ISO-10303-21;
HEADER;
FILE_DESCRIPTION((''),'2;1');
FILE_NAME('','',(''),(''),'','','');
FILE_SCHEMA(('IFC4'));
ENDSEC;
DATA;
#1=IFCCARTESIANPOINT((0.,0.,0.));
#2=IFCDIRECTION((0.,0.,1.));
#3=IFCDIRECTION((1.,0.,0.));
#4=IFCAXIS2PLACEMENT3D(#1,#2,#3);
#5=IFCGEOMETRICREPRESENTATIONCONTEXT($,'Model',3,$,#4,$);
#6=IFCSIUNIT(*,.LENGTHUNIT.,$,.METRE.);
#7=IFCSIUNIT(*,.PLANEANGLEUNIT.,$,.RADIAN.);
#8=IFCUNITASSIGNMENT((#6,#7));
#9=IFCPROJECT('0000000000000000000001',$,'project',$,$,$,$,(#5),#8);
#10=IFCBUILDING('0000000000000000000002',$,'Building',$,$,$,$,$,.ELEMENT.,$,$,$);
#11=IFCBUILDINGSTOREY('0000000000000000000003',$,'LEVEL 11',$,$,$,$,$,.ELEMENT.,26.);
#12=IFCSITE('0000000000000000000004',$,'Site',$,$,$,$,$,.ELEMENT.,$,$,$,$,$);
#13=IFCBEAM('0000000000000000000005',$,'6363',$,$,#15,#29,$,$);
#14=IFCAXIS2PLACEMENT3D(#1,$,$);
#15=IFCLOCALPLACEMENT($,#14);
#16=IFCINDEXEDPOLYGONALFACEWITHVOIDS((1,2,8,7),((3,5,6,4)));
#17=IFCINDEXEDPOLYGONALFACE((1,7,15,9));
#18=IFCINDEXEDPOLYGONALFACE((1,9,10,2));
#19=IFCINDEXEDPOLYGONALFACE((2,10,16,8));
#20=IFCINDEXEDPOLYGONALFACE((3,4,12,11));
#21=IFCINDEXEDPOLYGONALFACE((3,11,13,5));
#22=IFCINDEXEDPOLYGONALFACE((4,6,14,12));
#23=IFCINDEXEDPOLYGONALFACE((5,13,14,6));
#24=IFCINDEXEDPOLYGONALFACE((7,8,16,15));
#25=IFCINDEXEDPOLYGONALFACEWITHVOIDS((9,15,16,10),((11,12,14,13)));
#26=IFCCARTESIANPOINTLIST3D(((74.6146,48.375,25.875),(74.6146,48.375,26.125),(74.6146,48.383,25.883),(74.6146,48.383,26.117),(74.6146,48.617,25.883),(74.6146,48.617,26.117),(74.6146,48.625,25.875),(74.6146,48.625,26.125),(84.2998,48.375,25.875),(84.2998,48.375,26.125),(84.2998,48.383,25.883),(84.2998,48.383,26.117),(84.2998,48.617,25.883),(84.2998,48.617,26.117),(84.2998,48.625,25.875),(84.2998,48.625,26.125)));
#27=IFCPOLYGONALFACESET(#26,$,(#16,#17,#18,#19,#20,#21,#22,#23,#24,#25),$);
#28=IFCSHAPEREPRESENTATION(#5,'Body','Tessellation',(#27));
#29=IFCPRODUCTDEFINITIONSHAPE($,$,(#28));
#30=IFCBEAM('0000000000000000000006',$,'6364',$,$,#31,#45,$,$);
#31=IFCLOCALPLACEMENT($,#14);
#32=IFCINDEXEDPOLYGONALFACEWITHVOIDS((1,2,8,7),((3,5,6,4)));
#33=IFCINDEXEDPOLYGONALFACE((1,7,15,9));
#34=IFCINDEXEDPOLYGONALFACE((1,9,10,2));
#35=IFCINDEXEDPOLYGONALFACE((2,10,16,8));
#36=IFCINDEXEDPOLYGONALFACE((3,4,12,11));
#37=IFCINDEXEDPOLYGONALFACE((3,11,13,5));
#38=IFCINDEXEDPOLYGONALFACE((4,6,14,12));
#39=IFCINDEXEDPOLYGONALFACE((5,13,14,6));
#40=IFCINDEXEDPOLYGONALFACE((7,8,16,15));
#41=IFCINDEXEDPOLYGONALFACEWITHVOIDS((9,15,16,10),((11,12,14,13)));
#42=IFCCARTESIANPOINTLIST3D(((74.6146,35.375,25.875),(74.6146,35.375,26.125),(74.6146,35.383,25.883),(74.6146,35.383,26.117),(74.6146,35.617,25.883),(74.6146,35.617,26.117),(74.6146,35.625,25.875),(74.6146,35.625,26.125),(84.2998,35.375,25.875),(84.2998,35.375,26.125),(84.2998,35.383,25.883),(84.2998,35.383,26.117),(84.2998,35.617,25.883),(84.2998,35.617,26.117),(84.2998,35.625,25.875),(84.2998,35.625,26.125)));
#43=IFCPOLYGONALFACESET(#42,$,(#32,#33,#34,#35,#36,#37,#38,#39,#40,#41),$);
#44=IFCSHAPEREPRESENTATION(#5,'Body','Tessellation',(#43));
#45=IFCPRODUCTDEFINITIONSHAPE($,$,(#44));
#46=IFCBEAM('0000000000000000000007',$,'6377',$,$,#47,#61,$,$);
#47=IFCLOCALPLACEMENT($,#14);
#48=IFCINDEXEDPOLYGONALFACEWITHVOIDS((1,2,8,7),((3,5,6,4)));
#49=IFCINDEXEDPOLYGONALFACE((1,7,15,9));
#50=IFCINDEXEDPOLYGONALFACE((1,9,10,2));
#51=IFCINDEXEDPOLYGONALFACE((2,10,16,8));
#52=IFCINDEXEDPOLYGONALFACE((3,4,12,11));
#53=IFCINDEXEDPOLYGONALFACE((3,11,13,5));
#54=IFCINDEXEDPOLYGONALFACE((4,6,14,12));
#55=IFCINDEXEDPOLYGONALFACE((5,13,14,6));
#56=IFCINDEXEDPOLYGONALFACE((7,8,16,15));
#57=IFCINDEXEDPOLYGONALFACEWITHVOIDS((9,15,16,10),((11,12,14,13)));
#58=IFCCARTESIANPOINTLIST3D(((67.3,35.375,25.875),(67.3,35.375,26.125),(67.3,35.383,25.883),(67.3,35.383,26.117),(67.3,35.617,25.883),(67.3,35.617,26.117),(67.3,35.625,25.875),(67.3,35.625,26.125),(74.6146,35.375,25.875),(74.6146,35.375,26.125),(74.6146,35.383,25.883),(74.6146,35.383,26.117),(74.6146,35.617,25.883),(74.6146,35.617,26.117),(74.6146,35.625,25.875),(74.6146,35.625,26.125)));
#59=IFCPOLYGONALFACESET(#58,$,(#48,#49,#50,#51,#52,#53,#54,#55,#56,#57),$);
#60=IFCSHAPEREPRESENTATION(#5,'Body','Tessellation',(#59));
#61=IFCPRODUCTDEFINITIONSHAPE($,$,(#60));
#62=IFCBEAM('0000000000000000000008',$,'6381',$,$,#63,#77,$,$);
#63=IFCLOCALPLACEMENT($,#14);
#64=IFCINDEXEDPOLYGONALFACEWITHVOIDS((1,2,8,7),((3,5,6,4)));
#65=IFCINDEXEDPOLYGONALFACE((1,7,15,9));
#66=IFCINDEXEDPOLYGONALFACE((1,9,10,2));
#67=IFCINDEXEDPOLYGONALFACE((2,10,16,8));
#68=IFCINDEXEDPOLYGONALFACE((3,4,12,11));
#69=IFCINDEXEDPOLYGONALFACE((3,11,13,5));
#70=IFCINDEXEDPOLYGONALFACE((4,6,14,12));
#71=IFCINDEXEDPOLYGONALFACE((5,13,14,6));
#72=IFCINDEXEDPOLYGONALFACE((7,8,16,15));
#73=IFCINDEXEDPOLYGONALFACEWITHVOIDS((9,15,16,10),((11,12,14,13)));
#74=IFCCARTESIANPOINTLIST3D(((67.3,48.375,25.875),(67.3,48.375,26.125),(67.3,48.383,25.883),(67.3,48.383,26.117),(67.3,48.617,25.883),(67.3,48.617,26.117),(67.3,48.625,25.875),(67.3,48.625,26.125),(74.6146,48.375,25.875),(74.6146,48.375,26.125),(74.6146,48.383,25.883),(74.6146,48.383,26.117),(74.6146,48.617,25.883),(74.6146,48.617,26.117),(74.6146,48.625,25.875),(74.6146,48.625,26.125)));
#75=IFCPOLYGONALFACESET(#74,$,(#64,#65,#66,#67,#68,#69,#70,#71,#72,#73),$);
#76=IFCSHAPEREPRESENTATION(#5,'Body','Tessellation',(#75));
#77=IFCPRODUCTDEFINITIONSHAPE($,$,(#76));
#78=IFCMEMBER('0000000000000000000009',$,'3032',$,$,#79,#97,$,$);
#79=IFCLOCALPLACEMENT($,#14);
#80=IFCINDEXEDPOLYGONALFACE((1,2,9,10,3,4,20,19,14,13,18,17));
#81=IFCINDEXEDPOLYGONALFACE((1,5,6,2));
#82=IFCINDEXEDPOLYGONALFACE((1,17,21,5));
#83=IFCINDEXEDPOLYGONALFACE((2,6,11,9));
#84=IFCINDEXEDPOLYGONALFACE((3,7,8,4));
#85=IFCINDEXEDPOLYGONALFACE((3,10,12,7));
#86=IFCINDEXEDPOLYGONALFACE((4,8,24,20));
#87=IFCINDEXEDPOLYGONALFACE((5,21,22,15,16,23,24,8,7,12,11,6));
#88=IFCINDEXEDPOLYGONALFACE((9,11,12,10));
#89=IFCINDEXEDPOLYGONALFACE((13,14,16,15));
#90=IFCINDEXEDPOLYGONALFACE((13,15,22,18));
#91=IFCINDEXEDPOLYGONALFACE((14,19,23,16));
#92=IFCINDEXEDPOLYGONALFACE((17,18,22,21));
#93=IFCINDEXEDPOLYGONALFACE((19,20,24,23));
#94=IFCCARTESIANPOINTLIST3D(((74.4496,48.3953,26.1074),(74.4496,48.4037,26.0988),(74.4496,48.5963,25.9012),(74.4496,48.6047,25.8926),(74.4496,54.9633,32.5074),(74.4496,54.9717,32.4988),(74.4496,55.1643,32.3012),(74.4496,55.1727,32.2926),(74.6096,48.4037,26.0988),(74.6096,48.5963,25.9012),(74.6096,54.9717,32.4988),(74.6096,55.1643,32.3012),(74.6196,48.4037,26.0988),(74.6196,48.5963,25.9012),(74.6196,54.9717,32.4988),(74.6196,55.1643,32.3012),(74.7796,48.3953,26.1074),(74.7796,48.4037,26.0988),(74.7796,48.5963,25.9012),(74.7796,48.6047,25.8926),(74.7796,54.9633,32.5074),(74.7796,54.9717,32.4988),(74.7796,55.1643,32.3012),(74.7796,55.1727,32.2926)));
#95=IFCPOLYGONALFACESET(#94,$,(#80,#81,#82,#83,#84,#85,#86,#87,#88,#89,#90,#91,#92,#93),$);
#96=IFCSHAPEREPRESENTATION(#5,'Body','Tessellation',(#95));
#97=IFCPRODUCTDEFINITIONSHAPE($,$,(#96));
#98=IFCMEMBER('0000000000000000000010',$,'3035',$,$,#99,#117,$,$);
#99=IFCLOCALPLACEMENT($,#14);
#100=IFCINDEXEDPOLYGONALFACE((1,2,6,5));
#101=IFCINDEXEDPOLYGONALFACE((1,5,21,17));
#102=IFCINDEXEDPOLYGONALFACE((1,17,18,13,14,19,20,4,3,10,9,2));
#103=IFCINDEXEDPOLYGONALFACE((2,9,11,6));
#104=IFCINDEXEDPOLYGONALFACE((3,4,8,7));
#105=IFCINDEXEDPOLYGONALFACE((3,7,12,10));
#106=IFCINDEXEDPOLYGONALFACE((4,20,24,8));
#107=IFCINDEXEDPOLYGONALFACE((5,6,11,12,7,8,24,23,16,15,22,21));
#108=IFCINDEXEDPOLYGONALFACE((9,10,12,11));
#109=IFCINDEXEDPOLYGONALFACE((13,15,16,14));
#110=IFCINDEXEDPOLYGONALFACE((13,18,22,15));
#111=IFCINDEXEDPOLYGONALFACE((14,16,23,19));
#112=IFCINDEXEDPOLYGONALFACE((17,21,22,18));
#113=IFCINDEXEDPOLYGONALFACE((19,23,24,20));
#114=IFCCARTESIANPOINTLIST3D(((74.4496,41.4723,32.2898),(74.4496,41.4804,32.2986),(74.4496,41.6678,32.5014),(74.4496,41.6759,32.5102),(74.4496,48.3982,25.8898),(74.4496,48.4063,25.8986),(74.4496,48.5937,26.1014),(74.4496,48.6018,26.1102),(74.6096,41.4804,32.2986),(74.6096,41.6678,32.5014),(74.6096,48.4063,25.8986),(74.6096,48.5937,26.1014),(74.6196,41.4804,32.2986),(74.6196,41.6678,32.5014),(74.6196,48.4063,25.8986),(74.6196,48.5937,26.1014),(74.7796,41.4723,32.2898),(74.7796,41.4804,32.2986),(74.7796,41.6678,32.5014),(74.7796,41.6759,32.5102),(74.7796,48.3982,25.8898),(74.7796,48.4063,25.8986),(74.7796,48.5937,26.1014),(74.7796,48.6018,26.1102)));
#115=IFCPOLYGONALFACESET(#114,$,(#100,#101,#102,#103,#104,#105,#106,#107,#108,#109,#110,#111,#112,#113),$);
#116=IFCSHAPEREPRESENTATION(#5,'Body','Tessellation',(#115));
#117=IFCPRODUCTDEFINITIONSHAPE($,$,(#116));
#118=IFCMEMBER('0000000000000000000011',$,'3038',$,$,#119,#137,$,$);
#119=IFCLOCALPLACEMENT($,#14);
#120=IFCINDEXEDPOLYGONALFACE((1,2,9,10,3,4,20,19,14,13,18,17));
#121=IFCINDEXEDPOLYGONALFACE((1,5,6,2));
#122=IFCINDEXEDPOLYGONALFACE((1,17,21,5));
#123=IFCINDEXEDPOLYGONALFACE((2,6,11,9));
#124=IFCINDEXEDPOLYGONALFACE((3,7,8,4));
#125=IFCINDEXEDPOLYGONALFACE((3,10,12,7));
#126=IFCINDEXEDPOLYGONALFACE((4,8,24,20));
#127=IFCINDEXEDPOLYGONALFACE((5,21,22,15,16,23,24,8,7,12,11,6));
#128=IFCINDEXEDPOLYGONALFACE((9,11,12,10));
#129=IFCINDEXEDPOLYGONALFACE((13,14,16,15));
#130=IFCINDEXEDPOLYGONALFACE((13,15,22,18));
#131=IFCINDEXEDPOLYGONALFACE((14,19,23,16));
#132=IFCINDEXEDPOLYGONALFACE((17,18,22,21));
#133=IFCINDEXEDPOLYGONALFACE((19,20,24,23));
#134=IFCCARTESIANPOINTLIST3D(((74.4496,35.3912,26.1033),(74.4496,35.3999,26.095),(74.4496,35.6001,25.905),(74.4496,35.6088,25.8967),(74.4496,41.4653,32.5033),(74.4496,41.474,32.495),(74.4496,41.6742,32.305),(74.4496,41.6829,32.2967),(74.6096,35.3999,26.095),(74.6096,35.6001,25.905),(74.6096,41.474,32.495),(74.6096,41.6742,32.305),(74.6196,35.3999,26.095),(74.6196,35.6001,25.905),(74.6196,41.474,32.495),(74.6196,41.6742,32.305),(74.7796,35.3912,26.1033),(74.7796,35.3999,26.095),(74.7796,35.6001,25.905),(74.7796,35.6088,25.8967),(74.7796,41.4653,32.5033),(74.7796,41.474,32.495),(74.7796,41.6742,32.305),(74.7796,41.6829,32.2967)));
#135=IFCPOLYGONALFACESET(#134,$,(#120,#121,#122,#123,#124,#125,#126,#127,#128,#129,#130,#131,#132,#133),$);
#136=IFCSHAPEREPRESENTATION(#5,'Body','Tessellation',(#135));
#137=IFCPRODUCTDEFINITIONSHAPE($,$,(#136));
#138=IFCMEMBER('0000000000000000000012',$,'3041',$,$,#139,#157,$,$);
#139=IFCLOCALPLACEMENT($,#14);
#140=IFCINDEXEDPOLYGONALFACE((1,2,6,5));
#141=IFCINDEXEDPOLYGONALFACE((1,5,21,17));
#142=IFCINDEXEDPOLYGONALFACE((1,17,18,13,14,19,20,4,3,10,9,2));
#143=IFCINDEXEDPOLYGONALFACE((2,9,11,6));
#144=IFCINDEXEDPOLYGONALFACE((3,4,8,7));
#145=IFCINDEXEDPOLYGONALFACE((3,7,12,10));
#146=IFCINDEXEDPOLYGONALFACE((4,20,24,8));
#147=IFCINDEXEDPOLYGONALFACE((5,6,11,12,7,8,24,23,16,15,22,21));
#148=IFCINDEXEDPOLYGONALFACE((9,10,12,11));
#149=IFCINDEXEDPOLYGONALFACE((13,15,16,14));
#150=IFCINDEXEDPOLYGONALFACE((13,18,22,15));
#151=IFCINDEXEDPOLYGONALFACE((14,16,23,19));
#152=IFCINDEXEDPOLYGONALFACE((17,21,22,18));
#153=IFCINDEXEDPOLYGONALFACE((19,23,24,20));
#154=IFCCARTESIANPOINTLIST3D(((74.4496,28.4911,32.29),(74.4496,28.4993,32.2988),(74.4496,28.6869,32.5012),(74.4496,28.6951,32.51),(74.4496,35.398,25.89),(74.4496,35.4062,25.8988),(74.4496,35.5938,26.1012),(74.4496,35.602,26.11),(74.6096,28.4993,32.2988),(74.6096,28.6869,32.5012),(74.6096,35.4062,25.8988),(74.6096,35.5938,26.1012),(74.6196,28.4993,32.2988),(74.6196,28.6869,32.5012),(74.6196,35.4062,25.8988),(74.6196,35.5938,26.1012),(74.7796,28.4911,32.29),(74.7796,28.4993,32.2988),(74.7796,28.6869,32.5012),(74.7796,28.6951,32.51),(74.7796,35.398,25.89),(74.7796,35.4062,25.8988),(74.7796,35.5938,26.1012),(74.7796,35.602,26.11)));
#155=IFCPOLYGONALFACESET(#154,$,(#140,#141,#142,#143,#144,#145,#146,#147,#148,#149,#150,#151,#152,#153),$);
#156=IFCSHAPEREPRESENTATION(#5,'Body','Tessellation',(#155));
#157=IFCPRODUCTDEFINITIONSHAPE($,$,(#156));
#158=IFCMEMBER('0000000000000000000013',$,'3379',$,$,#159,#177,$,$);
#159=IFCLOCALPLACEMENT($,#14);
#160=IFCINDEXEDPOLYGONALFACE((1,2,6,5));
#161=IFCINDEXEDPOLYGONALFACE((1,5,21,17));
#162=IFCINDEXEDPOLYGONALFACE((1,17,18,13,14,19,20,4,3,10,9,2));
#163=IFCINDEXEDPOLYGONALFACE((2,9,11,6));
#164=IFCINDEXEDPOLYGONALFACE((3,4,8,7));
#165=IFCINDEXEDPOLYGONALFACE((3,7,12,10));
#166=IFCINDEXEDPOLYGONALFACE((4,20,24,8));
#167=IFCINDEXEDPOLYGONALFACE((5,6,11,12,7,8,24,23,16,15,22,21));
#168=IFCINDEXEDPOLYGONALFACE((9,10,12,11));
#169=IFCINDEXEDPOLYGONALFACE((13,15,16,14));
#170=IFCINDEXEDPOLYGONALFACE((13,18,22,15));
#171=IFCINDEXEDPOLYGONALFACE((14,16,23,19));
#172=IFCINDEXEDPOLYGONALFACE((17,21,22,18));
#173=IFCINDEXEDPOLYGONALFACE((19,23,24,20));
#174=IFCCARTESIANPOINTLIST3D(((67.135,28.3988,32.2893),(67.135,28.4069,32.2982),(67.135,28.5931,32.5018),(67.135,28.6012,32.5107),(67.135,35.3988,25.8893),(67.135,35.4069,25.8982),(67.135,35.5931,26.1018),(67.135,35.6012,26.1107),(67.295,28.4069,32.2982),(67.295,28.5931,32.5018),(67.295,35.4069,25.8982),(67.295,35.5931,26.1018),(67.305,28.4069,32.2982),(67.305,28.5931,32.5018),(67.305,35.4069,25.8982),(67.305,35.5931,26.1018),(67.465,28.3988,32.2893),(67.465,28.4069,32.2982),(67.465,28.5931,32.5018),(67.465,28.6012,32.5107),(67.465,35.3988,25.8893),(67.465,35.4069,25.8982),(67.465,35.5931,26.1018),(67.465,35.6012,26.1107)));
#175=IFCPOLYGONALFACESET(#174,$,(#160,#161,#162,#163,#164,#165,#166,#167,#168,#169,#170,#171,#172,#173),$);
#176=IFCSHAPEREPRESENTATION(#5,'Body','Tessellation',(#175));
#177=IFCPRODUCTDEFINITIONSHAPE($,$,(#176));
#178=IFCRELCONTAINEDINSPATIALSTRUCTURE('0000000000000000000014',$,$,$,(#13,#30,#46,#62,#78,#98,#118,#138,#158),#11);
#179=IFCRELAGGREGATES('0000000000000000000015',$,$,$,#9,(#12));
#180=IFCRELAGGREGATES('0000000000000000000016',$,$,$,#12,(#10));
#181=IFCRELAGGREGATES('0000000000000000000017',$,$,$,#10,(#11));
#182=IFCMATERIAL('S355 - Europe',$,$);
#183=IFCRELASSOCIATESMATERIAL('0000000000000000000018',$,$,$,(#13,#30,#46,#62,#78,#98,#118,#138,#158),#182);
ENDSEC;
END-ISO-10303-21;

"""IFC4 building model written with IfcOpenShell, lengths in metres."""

from ifc_helpers import new_model, si_unit, frame, origin_with_axes, origin_2d_with_axis, place, context, project, spatial, hollow_rectangle, i_section, extrude, material, material_profile, profile_set, profile_usage, element, save


model = new_model("IFC4")

# Units and contexts
model_context = context("Model", 3, world=origin_with_axes())
ifc_project = project(units=[si_unit("LENGTHUNIT", "METRE"), si_unit("PLANEANGLEUNIT", "RADIAN")], contexts=[model_context])

# Site, building, storey
site = spatial("IfcSite", under=ifc_project, Name="Site", CompositionType="ELEMENT")
building = spatial("IfcBuilding", under=site, Name="Building", CompositionType="ELEMENT")
storey = spatial("IfcBuildingStorey", under=building, Name="LEVEL 11", CompositionType="ELEMENT", Elevation=26.0)

# Shared definitions
ifc_material = material(Name="S355 - Europe")

# Beams
ifc_material_profile_1 = material_profile(ifc_material, hollow_rectangle(XDim=0.25, YDim=0.25, WallThickness=0.008, at=origin_2d_with_axis()))
ifc_profile_set_1 = profile_set([ifc_material_profile_1])
ifc_profile_usage_1 = profile_usage(ifc_profile_set_1, cardinal=10)
beam_1_placement = place(None, frame((74.6146, 48.5, 26.0), z_axis=(1.0, 0.0, 0.0), x_axis=(0.0, 1.0, 0.0)))
element("IfcBeam", 1, at=beam_1_placement, inside=storey, material=ifc_profile_usage_1, Name="6363", context=model_context, shape_type="SweptSolid", body=[
    extrude(hollow_rectangle(XDim=0.25, YDim=0.25, WallThickness=0.008, at=origin_2d_with_axis()), origin_with_axes(), (0.0, 0.0, 1.0), 9.6852),
])
ifc_material_profile_2 = material_profile(ifc_material, hollow_rectangle(XDim=0.25, YDim=0.25, WallThickness=0.008, at=origin_2d_with_axis()))
ifc_profile_set_2 = profile_set([ifc_material_profile_2])
ifc_profile_usage_2 = profile_usage(ifc_profile_set_2, cardinal=10)
beam_2_placement = place(None, frame((74.6146, 35.5, 26.0), z_axis=(1.0, 0.0, 0.0), x_axis=(0.0, 1.0, 0.0)))
element("IfcBeam", 2, at=beam_2_placement, inside=storey, material=ifc_profile_usage_2, Name="6364", context=model_context, shape_type="SweptSolid", body=[
    extrude(hollow_rectangle(XDim=0.25, YDim=0.25, WallThickness=0.008, at=origin_2d_with_axis()), origin_with_axes(), (0.0, 0.0, 1.0), 9.6852),
])
ifc_material_profile_3 = material_profile(ifc_material, hollow_rectangle(XDim=0.25, YDim=0.25, WallThickness=0.008, at=origin_2d_with_axis()))
ifc_profile_set_3 = profile_set([ifc_material_profile_3])
ifc_profile_usage_3 = profile_usage(ifc_profile_set_3, cardinal=10)
beam_3_placement = place(None, frame((67.3, 35.5, 26.0), z_axis=(1.0, 0.0, 0.0), x_axis=(0.0, 1.0, 0.0)))
element("IfcBeam", 3, at=beam_3_placement, inside=storey, material=ifc_profile_usage_3, Name="6377", context=model_context, shape_type="SweptSolid", body=[
    extrude(hollow_rectangle(XDim=0.25, YDim=0.25, WallThickness=0.008, at=origin_2d_with_axis()), origin_with_axes(), (0.0, 0.0, 1.0), 7.3146),
])
ifc_material_profile_4 = material_profile(ifc_material, hollow_rectangle(XDim=0.25, YDim=0.25, WallThickness=0.008, at=origin_2d_with_axis()))
ifc_profile_set_4 = profile_set([ifc_material_profile_4])
ifc_profile_usage_4 = profile_usage(ifc_profile_set_4, cardinal=10)
beam_4_placement = place(None, frame((67.3, 48.5, 26.0), z_axis=(1.0, 0.0, 0.0), x_axis=(0.0, 1.0, 0.0)))
element("IfcBeam", 4, at=beam_4_placement, inside=storey, material=ifc_profile_usage_4, Name="6381", context=model_context, shape_type="SweptSolid", body=[
    extrude(hollow_rectangle(XDim=0.25, YDim=0.25, WallThickness=0.008, at=origin_2d_with_axis()), origin_with_axes(), (0.0, 0.0, 1.0), 7.3146),
])

# Members
ifc_material_profile_5 = material_profile(ifc_material, i_section(OverallWidth=0.33, OverallDepth=0.3, WebThickness=0.01, FlangeThickness=0.012, at=origin_2d_with_axis()))
ifc_profile_set_5 = profile_set([ifc_material_profile_5])
ifc_profile_usage_5 = profile_usage(ifc_profile_set_5, cardinal=10)
member_1_placement = place(None, frame((74.6146, 48.5, 26.0), z_axis=(0.0, 0.716207, 0.697888), x_axis=(-1.0, 0.0, 0.0)))
element("IfcMember", 5, at=member_1_placement, inside=storey, material=ifc_profile_usage_5, Name="3032", context=model_context, shape_type="SweptSolid", body=[
    extrude(i_section(OverallWidth=0.33, OverallDepth=0.3, WebThickness=0.01, FlangeThickness=0.012, at=origin_2d_with_axis()), origin_with_axes(), (0.0, 0.0, 1.0), 9.1705),
])
ifc_material_profile_6 = material_profile(ifc_material, i_section(OverallWidth=0.33, OverallDepth=0.3, WebThickness=0.01, FlangeThickness=0.012, at=origin_2d_with_axis()))
ifc_profile_set_6 = profile_set([ifc_material_profile_6])
ifc_profile_usage_6 = profile_usage(ifc_profile_set_6, cardinal=10)
member_2_placement = place(None, frame((74.6146, 41.5741, 32.4), z_axis=(0.0, 0.734441, -0.678673), x_axis=(-1.0, 0.0, 0.0)))
element("IfcMember", 6, at=member_2_placement, inside=storey, material=ifc_profile_usage_6, Name="3035", context=model_context, shape_type="SweptSolid", body=[
    extrude(i_section(OverallWidth=0.33, OverallDepth=0.3, WebThickness=0.01, FlangeThickness=0.012, at=origin_2d_with_axis()), origin_with_axes(), (0.0, 0.0, 1.0), 9.4302),
])
ifc_material_profile_7 = material_profile(ifc_material, i_section(OverallWidth=0.33, OverallDepth=0.3, WebThickness=0.01, FlangeThickness=0.012, at=origin_2d_with_axis()))
ifc_profile_set_7 = profile_set([ifc_material_profile_7])
ifc_profile_usage_7 = profile_usage(ifc_profile_set_7, cardinal=10)
member_3_placement = place(None, frame((74.6146, 35.5, 26.0), z_axis=(0.0, 0.688398, 0.725333), x_axis=(-1.0, 0.0, 0.0)))
element("IfcMember", 7, at=member_3_placement, inside=storey, material=ifc_profile_usage_7, Name="3038", context=model_context, shape_type="SweptSolid", body=[
    extrude(i_section(OverallWidth=0.33, OverallDepth=0.3, WebThickness=0.01, FlangeThickness=0.012, at=origin_2d_with_axis()), origin_with_axes(), (0.0, 0.0, 1.0), 8.8235),
])
ifc_material_profile_8 = material_profile(ifc_material, i_section(OverallWidth=0.33, OverallDepth=0.3, WebThickness=0.01, FlangeThickness=0.012, at=origin_2d_with_axis()))
ifc_profile_set_8 = profile_set([ifc_material_profile_8])
ifc_profile_usage_8 = profile_usage(ifc_profile_set_8, cardinal=10)
member_4_placement = place(None, frame((74.6146, 28.5931, 32.4), z_axis=(0.0, 0.733511, -0.679678), x_axis=(-1.0, 0.0, 0.0)))
element("IfcMember", 8, at=member_4_placement, inside=storey, material=ifc_profile_usage_8, Name="3041", context=model_context, shape_type="SweptSolid", body=[
    extrude(i_section(OverallWidth=0.33, OverallDepth=0.3, WebThickness=0.01, FlangeThickness=0.012, at=origin_2d_with_axis()), origin_with_axes(), (0.0, 0.0, 1.0), 9.4162),
])
ifc_material_profile_9 = material_profile(ifc_material, i_section(OverallWidth=0.33, OverallDepth=0.3, WebThickness=0.01, FlangeThickness=0.012, at=origin_2d_with_axis()))
ifc_profile_set_9 = profile_set([ifc_material_profile_9])
ifc_profile_usage_9 = profile_usage(ifc_profile_set_9, cardinal=10)
member_5_placement = place(None, frame((67.3, 28.5, 32.4), z_axis=(0.0, 0.738029, -0.674769), x_axis=(-1.0, 0.0, 0.0)))
element("IfcMember", 9, at=member_5_placement, inside=storey, material=ifc_profile_usage_9, Name="3379", context=model_context, shape_type="SweptSolid", body=[
    extrude(i_section(OverallWidth=0.33, OverallDepth=0.3, WebThickness=0.01, FlangeThickness=0.012, at=origin_2d_with_axis()), origin_with_axes(), (0.0, 0.0, 1.0), 9.4847),
])

save(model, "model.ifc")
